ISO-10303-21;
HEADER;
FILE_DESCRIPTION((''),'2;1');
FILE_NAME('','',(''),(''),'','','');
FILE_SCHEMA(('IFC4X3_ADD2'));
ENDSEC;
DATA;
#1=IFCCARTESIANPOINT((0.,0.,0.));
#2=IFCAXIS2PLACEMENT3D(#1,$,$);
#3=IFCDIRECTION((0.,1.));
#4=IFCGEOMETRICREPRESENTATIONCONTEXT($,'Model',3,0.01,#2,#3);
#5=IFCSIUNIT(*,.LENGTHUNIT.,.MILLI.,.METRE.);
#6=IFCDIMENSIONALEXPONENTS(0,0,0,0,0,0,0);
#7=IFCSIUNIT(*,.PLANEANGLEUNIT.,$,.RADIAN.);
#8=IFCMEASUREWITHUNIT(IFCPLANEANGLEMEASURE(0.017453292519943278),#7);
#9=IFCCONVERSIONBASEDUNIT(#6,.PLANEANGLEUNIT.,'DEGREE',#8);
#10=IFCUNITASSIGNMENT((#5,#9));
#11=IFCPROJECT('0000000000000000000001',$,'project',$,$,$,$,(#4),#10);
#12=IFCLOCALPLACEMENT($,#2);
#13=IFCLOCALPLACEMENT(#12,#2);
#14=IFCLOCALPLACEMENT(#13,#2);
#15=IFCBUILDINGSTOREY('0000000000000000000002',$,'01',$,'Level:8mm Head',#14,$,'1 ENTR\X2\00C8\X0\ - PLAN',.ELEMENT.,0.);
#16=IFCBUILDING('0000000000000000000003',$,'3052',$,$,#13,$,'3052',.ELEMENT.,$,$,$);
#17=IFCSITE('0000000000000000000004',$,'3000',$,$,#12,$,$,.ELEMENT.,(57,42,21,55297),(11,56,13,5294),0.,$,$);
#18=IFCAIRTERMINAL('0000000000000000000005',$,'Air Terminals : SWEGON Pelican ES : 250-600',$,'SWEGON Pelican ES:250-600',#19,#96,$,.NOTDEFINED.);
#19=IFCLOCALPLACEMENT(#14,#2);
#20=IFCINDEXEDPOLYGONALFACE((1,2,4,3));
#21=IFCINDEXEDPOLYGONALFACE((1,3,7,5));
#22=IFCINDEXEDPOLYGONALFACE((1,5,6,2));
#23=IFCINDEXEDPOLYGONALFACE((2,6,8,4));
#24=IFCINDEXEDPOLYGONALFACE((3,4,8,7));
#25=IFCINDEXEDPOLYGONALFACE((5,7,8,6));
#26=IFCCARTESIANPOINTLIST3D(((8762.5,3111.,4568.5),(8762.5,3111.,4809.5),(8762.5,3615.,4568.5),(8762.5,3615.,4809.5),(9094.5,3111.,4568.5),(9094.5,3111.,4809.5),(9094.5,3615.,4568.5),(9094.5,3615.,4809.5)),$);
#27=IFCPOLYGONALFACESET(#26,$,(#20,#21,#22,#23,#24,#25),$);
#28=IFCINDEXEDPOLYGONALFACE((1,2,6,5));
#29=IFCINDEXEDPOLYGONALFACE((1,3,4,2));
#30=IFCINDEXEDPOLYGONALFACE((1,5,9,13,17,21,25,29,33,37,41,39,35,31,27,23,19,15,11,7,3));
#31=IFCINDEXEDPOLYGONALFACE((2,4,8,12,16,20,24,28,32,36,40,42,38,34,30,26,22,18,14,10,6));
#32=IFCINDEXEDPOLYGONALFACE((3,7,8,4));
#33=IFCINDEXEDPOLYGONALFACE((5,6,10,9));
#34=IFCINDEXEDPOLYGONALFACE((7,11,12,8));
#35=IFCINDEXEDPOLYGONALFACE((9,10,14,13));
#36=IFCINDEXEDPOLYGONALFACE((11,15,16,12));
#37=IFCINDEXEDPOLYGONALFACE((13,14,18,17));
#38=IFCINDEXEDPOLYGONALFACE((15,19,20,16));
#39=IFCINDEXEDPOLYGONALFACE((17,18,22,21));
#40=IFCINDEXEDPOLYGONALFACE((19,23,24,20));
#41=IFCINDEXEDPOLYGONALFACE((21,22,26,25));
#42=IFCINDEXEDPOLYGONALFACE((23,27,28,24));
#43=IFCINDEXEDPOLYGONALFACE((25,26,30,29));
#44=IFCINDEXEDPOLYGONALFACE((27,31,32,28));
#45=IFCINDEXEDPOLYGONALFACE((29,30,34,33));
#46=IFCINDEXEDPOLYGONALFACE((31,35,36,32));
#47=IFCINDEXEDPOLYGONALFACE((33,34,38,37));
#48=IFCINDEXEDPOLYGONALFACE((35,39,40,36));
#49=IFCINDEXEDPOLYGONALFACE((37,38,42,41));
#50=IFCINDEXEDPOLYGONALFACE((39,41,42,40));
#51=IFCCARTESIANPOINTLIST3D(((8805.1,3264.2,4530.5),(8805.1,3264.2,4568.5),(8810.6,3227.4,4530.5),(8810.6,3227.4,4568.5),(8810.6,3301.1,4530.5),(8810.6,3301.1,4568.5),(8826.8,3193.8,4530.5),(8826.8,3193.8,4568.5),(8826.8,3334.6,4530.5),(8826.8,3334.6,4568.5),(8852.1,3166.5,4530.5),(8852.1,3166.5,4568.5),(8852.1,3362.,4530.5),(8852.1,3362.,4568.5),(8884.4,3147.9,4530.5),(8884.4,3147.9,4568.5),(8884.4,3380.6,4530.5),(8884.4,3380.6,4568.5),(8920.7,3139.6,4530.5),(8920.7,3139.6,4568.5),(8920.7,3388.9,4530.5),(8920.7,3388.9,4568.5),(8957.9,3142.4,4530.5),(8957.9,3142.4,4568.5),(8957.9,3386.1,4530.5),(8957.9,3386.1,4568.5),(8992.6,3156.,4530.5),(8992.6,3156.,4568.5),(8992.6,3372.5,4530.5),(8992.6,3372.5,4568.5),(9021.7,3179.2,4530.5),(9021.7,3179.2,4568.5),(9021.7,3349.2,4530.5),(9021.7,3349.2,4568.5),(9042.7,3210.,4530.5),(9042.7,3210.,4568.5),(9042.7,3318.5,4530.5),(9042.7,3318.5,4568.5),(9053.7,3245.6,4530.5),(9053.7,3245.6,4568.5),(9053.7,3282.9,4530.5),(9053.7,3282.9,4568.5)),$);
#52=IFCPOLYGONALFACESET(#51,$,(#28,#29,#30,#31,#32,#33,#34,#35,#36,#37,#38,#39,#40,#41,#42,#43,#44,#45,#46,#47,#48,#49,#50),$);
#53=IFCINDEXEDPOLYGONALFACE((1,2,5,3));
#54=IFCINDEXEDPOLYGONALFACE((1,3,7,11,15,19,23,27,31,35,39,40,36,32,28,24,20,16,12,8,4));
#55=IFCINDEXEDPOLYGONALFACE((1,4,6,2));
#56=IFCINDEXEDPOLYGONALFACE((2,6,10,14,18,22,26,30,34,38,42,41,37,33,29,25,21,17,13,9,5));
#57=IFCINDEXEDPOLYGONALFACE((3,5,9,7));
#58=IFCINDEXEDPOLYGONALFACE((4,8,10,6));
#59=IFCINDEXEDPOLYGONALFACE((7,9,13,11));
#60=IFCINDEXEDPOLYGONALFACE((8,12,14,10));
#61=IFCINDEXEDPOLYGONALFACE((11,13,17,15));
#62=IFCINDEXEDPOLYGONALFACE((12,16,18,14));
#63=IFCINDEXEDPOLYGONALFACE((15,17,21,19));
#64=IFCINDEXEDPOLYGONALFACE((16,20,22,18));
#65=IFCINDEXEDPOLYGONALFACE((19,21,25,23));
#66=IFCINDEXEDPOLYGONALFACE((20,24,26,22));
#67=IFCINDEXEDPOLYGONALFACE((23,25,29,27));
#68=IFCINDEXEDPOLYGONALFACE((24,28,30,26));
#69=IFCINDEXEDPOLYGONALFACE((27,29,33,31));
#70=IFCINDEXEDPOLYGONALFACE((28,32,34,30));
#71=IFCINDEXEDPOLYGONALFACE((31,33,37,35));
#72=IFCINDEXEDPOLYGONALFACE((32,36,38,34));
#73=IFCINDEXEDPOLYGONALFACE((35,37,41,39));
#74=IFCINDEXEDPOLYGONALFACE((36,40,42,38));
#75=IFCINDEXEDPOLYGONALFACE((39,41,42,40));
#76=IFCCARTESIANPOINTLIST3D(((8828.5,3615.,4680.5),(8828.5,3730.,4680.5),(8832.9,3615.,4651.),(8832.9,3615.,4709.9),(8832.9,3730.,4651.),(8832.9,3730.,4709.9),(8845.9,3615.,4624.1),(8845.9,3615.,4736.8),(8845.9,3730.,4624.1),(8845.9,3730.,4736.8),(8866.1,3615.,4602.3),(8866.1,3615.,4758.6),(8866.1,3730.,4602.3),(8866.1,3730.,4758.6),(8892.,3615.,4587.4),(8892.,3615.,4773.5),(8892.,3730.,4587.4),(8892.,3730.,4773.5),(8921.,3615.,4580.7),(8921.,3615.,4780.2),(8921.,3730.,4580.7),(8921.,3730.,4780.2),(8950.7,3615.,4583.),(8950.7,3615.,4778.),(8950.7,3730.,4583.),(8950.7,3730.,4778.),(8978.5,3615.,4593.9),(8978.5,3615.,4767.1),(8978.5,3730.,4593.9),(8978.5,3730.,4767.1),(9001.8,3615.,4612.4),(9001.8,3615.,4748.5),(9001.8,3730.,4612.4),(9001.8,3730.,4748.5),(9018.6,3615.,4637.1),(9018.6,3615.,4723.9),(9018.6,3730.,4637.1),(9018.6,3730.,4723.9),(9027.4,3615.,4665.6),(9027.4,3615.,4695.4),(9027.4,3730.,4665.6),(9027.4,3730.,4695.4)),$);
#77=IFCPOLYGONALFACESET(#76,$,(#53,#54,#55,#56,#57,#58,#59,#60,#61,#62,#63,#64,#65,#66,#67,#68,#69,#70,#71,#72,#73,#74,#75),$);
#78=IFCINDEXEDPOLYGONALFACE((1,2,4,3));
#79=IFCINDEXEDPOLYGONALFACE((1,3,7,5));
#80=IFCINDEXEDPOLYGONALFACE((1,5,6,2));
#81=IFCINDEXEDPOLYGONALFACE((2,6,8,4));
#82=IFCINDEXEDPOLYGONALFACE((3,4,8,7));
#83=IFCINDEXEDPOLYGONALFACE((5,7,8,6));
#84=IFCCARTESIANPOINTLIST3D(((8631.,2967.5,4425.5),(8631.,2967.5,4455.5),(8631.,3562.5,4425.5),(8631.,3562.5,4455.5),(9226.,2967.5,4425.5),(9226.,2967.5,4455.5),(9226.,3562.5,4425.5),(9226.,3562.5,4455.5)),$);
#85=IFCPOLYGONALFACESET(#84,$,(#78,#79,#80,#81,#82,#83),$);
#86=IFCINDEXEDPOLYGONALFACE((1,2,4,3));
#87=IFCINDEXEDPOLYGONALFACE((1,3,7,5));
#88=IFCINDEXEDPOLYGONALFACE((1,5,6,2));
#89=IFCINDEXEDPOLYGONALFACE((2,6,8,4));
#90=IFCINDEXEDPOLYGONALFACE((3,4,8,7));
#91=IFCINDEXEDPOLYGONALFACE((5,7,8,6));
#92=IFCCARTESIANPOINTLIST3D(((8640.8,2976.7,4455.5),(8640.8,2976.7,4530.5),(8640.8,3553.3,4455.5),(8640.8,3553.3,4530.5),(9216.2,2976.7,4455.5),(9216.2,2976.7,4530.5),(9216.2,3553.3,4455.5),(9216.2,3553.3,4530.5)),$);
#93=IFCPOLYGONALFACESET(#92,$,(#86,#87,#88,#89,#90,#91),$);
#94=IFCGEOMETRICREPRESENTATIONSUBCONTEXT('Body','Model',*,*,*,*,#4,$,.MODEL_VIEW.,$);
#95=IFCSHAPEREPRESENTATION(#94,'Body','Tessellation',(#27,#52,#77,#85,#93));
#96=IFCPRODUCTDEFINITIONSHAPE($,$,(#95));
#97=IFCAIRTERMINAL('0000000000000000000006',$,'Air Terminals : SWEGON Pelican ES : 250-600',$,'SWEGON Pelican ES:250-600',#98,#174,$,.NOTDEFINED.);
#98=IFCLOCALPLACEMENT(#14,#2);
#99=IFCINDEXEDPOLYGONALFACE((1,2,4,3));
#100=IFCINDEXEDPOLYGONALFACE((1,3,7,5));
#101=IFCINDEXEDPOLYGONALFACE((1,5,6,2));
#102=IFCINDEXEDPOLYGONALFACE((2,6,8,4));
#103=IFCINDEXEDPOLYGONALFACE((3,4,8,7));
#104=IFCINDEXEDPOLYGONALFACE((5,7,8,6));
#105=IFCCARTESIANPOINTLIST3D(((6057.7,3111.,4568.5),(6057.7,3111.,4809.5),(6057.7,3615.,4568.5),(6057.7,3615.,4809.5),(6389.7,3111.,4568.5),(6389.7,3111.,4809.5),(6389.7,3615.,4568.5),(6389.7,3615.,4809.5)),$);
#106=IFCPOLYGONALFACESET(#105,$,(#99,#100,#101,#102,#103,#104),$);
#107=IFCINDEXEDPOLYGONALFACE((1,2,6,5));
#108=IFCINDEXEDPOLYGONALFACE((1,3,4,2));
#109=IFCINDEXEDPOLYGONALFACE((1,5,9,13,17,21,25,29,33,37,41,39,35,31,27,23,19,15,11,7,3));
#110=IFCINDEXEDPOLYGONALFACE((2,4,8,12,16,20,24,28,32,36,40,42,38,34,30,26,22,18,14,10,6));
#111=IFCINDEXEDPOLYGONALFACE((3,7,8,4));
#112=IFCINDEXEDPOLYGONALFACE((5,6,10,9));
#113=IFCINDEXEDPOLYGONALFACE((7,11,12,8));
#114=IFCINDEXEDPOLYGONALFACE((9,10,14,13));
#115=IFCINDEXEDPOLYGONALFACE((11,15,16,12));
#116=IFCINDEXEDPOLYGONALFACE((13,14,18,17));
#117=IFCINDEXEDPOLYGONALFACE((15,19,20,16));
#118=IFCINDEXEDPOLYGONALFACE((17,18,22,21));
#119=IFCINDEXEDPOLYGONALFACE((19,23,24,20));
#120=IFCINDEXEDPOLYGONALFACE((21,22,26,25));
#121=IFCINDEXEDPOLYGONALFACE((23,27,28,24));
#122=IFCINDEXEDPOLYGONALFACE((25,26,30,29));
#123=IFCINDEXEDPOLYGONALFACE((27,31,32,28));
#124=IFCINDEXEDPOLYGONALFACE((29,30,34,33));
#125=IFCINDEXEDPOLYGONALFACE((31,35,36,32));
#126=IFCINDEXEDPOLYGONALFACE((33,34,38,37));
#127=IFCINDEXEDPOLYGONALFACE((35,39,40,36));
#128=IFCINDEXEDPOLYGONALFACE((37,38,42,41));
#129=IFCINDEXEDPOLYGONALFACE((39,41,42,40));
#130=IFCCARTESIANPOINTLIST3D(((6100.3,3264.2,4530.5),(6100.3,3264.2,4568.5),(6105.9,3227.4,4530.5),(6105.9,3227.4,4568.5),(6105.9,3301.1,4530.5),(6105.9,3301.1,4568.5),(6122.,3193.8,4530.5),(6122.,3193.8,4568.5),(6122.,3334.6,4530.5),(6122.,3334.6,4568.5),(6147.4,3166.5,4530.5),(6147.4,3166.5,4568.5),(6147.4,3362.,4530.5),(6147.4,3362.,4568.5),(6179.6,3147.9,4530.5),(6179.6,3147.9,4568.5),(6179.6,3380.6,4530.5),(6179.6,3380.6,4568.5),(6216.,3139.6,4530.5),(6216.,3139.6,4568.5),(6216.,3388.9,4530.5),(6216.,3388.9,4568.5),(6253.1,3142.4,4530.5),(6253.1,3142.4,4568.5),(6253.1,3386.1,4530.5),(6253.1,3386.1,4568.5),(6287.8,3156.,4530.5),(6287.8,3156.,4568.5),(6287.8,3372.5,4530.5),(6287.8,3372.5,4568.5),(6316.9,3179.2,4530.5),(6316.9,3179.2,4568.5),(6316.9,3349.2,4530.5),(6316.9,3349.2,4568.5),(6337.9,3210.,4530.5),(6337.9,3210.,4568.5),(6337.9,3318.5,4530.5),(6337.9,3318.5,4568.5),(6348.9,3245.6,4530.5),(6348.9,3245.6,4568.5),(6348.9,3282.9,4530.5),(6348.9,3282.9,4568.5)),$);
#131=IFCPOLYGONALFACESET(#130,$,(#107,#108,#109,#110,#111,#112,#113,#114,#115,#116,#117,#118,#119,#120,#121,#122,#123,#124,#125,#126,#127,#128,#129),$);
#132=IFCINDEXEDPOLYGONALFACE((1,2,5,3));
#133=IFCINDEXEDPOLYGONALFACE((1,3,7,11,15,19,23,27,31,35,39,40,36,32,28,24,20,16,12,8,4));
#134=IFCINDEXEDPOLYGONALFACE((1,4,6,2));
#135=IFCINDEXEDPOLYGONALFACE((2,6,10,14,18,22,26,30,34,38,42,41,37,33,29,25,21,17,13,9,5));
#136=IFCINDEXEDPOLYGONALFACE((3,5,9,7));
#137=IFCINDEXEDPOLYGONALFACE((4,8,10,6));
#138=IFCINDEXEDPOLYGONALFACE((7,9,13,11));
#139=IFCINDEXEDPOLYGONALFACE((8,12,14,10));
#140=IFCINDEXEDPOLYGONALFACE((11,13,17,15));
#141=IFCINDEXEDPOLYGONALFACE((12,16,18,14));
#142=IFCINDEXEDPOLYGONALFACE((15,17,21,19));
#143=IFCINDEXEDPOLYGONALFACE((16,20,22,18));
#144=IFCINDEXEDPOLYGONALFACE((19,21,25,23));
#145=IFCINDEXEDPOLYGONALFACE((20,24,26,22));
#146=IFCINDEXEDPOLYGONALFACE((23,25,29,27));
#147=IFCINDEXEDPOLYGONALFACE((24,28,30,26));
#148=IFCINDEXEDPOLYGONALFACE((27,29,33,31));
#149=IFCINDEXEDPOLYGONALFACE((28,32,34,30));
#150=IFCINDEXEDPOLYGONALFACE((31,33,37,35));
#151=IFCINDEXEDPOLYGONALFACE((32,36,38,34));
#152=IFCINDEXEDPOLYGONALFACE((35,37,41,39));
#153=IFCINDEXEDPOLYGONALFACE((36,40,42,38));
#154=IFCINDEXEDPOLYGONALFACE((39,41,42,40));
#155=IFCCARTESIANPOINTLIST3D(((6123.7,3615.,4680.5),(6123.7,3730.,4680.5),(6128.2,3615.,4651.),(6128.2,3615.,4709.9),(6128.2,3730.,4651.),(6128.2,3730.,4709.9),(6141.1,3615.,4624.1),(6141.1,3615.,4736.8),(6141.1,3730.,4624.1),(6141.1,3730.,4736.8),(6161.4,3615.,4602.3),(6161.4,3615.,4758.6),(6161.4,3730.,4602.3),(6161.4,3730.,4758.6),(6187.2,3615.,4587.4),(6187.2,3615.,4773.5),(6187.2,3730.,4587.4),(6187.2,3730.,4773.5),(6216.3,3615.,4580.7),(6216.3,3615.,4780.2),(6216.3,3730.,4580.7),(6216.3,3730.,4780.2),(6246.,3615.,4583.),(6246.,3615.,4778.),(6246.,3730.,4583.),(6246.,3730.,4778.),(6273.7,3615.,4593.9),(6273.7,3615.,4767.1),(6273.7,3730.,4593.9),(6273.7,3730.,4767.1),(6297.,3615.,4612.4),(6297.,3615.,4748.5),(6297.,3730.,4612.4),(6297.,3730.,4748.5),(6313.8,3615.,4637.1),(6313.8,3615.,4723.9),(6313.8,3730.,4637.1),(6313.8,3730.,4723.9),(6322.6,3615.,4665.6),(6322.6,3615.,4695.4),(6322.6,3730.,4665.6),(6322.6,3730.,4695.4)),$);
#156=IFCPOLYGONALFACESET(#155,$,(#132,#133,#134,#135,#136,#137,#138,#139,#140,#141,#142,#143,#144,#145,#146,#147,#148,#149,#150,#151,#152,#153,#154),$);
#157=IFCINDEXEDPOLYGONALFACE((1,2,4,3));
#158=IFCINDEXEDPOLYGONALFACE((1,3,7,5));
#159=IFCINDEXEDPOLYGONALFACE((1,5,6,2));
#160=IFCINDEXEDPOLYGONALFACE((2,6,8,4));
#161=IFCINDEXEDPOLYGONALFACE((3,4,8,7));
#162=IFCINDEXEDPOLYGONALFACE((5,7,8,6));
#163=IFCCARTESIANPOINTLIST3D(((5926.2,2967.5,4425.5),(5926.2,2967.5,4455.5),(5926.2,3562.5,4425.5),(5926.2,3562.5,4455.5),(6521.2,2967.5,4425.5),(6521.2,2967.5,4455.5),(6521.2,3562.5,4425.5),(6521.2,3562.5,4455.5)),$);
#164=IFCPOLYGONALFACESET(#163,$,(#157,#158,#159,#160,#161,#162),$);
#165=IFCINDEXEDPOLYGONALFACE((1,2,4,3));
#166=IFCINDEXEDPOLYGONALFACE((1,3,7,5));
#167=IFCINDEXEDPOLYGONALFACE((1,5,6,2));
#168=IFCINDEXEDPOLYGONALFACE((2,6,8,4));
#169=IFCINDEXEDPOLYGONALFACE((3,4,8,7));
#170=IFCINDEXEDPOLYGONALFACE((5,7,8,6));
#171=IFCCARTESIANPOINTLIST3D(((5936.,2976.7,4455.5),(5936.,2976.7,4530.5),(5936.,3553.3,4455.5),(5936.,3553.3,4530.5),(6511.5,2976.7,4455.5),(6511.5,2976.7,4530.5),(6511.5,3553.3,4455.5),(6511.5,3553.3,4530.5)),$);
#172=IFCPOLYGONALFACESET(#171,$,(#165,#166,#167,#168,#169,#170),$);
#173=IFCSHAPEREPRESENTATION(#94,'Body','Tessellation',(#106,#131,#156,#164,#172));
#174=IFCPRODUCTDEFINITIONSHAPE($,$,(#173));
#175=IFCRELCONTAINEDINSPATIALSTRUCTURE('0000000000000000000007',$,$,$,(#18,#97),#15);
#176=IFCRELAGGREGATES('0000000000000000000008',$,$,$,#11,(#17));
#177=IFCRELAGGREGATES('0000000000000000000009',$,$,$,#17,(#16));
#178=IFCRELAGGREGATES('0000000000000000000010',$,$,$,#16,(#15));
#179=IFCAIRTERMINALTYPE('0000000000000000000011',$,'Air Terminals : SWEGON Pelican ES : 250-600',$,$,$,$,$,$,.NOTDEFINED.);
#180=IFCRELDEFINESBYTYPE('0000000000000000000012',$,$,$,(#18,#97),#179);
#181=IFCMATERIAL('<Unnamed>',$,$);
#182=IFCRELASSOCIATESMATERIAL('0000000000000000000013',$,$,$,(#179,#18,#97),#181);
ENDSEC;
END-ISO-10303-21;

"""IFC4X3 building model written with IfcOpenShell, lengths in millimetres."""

from ifc_helpers import new_model, entity, si_unit, converted_unit, direction, frame, frame_2d, origin, origin_2d_with_axis, place, context, subcontext, project, spatial, rectangle, circle, extrude, source, transform, mapped, material, type_object, type_shapes, element, save


model = new_model("IFC4X3")

# Units and contexts
model_context = context("Model", 3, precision=0.01, world=origin(), true_north=direction((0.0, 1.0)))
body_context = subcontext(model_context, "Body", "Model", "MODEL_VIEW")
ifc_project = project(units=[si_unit("LENGTHUNIT", "METRE", prefix="MILLI"), converted_unit("PLANEANGLEUNIT", "DEGREE", entity("IfcPlaneAngleMeasure", 0.017453292519943278), si_unit("PLANEANGLEUNIT", "RADIAN"), dimensions=[0, 0, 0, 0, 0, 0, 0])], contexts=[model_context])

# Site, building, storey
site_placement = place(None, origin())
site = spatial("IfcSite", under=ifc_project, at=site_placement, Name="3000", CompositionType="ELEMENT", RefLatitude=(57, 42, 21, 55297), RefLongitude=(11, 56, 13, 5294), RefElevation=0.0)
building_placement = place(site_placement, origin())
building = spatial("IfcBuilding", under=site, at=building_placement, Name="3052", LongName="3052", CompositionType="ELEMENT")
storey_placement = place(building_placement, origin())
storey = spatial("IfcBuildingStorey", under=building, at=storey_placement, Name="01", ObjectType="Level:8mm Head", LongName="1 ENTRÈ - PLAN", CompositionType="ELEMENT", Elevation=0.0)

# Air terminals
ifc_material_1 = material(Name="<Unnamed>")
air_terminal_type_1 = type_object("IfcAirTerminalType", Name="Air Terminals : SWEGON Pelican ES : 250-600", PredefinedType="NOTDEFINED", material=ifc_material_1)
shared_shape_1 = source(origin(), body_context, "Body", "SweptSolid", [
    extrude(rectangle(XDim=332.0, YDim=504.0, at=origin_2d_with_axis()), frame((0.0, 98.0, -354.0), z_axis=(0.0, 0.0, 1.0), x_axis=(-1.0, 0.0, 0.0)), (0.0, 0.0, 1.0), 241.0),
    extrude(circle(Radius=125.0, at=frame_2d((0.0, 0.0), x_axis=(1.0, 0.0))), frame((-1.6, -0.8, -113.0)), (0.0, 0.0, 1.0), 38.0),
    extrude(circle(Radius=100.0, at=frame_2d((0.0, 0.0), x_axis=(1.0, 0.0))), frame((0.0, 350.0, -225.0), z_axis=(0.0, 1.0, 0.0), x_axis=(1.0, 0.0, 0.0)), (0.0, 0.0, 1.0), 115.0),
    extrude(rectangle(XDim=595.0, YDim=595.0, at=frame_2d((0.0, 0.0), x_axis=(1.0, 0.0))), frame((0.0, 0.0, 0.0), z_axis=(0.0, 0.0, 1.0), x_axis=(-1.0, 0.0, 0.0)), (0.0, 0.0, 1.0), 30.0),
    extrude(rectangle(XDim=575.5, YDim=576.5, at=origin_2d_with_axis()), frame((0.0, 0.0, -75.0), z_axis=(0.0, 0.0, 1.0), x_axis=(-1.0, 0.0, 0.0)), (0.0, 0.0, 1.0), 75.0),
])
type_shapes(air_terminal_type_1, [shared_shape_1])
for number, where, z_axis, x_axis, name in (
    (1, (8928.5, 3265.0, 4455.5), (0.0, 0.0, -1.0), (-1.0, 0.0, 0.0), "Air Terminals : SWEGON Pelican ES : 250-600"),
    (2, (6223.7, 3265.0, 4455.5), (0.0, 0.0, -1.0), (-1.0, 0.0, 0.0), "Air Terminals : SWEGON Pelican ES : 250-600"),
):
    element("IfcAirTerminal", number, at=place(storey_placement, frame(where, z_axis=z_axis, x_axis=x_axis)), inside=storey, type_object=air_terminal_type_1, material=ifc_material_1, Name=name, ObjectType="SWEGON Pelican ES:250-600", PredefinedType="NOTDEFINED", context=body_context, shape_type="MappedRepresentation", body=[
        mapped(shared_shape_1, transform((0.0, 0.0, 0.0), scale=1.0)),
    ])

save(model, "model.ifc")
